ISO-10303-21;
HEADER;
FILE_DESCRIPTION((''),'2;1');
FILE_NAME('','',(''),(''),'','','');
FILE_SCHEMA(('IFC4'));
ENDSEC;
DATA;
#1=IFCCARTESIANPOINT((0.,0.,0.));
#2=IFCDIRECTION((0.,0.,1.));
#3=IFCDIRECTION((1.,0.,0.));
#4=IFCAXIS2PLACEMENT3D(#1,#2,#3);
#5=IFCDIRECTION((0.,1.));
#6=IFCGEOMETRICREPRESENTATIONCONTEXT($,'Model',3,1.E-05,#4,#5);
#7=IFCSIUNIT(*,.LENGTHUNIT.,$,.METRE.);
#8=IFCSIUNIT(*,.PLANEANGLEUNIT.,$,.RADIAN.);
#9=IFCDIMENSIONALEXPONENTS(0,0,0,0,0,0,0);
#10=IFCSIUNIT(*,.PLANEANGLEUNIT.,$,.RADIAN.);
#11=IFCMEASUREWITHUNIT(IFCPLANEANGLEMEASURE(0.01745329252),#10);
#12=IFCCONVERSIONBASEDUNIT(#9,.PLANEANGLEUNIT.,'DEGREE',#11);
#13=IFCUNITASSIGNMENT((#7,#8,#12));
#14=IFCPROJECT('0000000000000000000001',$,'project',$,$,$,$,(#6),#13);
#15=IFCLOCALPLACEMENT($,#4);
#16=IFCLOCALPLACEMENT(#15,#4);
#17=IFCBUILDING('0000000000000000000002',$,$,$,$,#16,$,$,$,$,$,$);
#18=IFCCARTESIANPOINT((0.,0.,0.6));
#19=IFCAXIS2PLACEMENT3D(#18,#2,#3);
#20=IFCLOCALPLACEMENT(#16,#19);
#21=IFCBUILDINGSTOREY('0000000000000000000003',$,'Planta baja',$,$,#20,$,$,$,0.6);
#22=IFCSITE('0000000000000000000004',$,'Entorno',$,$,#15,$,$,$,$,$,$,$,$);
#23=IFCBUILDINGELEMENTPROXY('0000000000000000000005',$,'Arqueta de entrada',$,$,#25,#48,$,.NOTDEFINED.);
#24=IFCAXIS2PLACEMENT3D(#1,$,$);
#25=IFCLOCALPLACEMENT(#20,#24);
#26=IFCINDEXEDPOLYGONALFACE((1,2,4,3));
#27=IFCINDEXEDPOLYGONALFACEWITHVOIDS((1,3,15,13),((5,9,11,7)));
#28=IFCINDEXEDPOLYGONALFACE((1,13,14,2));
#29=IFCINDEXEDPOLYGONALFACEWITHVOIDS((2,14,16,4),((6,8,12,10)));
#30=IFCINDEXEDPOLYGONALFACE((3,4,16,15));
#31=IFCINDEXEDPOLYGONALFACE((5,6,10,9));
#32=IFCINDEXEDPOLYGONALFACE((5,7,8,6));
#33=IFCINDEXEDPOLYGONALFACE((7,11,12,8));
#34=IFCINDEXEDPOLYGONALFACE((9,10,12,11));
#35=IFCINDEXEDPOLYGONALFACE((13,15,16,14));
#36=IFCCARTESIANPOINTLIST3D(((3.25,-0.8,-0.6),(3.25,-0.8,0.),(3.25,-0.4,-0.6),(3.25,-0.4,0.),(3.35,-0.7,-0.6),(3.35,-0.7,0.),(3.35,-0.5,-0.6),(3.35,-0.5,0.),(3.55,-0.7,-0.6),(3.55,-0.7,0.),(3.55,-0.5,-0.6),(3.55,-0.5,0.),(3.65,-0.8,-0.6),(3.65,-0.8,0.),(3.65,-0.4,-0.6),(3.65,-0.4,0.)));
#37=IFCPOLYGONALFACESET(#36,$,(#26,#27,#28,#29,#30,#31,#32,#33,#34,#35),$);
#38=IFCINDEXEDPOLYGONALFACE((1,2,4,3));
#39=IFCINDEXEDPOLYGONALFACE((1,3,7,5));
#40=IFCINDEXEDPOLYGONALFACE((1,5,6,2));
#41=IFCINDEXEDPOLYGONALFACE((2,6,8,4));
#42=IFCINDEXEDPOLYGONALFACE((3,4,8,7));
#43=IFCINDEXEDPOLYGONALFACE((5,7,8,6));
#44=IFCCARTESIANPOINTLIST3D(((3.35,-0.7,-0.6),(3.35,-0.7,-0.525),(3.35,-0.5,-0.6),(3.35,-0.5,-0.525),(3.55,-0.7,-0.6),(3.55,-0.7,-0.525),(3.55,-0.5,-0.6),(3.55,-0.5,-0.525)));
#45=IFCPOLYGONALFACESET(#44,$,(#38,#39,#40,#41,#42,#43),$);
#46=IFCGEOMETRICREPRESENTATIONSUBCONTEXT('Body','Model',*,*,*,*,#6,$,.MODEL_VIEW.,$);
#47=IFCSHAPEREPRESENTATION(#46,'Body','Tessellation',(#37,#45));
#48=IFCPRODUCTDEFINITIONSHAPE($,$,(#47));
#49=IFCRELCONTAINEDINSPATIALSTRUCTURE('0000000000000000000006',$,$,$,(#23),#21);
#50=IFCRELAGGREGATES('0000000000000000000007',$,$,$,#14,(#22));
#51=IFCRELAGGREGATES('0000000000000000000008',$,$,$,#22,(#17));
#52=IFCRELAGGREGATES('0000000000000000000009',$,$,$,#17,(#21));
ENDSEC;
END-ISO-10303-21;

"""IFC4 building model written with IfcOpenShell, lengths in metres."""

from ifc_helpers import new_model, entity, si_unit, converted_unit, direction, frame, origin_with_axes, place, context, subcontext, project, spatial, polyline, outline, extrude, element, save


model = new_model("IFC4")

# Units and contexts
model_context = context("Model", 3, precision=1e-05, world=origin_with_axes(), true_north=direction((0.0, 1.0)))
body_context = subcontext(model_context, "Body", "Model", "MODEL_VIEW")
ifc_project = project(units=[si_unit("LENGTHUNIT", "METRE"), si_unit("PLANEANGLEUNIT", "RADIAN"), converted_unit("PLANEANGLEUNIT", "DEGREE", entity("IfcPlaneAngleMeasure", 0.01745329252), si_unit("PLANEANGLEUNIT", "RADIAN"), dimensions=[0, 0, 0, 0, 0, 0, 0])], contexts=[model_context])

# Site, building, storey
site_placement = place(None, origin_with_axes())
site = spatial("IfcSite", under=ifc_project, at=site_placement, Name="Entorno")
building_placement = place(site_placement, origin_with_axes())
building = spatial("IfcBuilding", under=site, at=building_placement)
storey_placement = place(building_placement, frame((0.0, 0.0, 0.6), z_axis=(0.0, 0.0, 1.0), x_axis=(1.0, 0.0, 0.0)))
storey = spatial("IfcBuildingStorey", under=building, at=storey_placement, Name="Planta baja", Elevation=0.6)

# Building element proxy
proxy_1_placement = place(storey_placement, frame((0.0, 0.0, -0.6), z_axis=(0.0, 0.0, 1.0), x_axis=(1.0, 0.0, 0.0)))
element("IfcBuildingElementProxy", 1, at=proxy_1_placement, inside=storey, Name="Arqueta de entrada", PredefinedType="NOTDEFINED", context=body_context, shape_type="Brep", body=[
    extrude(outline(polyline([(-0.2, -0.2), (0.2, -0.2), (0.2, 0.2), (-0.2, 0.2), (-0.2, -0.2)]), holes=[polyline([(-0.1, -0.1), (0.1, -0.1), (0.1, 0.1), (-0.1, 0.1), (-0.1, -0.1)])]), frame((3.45, -0.6, 0.0), z_axis=(0.0, 0.0, 1.0), x_axis=(1.0, 0.0, 0.0)), (0.0, 0.0, 1.0), 0.6),
    extrude(outline(polyline([(-0.1, -0.1), (0.1, -0.1), (0.1, 0.1), (-0.1, 0.1), (-0.1, -0.1)])), frame((3.45, -0.6, 0.0), z_axis=(0.0, 0.0, 1.0), x_axis=(1.0, 0.0, 0.0)), (0.0, 0.0, 1.0), 0.075),
])

save(model, "model.ifc")
